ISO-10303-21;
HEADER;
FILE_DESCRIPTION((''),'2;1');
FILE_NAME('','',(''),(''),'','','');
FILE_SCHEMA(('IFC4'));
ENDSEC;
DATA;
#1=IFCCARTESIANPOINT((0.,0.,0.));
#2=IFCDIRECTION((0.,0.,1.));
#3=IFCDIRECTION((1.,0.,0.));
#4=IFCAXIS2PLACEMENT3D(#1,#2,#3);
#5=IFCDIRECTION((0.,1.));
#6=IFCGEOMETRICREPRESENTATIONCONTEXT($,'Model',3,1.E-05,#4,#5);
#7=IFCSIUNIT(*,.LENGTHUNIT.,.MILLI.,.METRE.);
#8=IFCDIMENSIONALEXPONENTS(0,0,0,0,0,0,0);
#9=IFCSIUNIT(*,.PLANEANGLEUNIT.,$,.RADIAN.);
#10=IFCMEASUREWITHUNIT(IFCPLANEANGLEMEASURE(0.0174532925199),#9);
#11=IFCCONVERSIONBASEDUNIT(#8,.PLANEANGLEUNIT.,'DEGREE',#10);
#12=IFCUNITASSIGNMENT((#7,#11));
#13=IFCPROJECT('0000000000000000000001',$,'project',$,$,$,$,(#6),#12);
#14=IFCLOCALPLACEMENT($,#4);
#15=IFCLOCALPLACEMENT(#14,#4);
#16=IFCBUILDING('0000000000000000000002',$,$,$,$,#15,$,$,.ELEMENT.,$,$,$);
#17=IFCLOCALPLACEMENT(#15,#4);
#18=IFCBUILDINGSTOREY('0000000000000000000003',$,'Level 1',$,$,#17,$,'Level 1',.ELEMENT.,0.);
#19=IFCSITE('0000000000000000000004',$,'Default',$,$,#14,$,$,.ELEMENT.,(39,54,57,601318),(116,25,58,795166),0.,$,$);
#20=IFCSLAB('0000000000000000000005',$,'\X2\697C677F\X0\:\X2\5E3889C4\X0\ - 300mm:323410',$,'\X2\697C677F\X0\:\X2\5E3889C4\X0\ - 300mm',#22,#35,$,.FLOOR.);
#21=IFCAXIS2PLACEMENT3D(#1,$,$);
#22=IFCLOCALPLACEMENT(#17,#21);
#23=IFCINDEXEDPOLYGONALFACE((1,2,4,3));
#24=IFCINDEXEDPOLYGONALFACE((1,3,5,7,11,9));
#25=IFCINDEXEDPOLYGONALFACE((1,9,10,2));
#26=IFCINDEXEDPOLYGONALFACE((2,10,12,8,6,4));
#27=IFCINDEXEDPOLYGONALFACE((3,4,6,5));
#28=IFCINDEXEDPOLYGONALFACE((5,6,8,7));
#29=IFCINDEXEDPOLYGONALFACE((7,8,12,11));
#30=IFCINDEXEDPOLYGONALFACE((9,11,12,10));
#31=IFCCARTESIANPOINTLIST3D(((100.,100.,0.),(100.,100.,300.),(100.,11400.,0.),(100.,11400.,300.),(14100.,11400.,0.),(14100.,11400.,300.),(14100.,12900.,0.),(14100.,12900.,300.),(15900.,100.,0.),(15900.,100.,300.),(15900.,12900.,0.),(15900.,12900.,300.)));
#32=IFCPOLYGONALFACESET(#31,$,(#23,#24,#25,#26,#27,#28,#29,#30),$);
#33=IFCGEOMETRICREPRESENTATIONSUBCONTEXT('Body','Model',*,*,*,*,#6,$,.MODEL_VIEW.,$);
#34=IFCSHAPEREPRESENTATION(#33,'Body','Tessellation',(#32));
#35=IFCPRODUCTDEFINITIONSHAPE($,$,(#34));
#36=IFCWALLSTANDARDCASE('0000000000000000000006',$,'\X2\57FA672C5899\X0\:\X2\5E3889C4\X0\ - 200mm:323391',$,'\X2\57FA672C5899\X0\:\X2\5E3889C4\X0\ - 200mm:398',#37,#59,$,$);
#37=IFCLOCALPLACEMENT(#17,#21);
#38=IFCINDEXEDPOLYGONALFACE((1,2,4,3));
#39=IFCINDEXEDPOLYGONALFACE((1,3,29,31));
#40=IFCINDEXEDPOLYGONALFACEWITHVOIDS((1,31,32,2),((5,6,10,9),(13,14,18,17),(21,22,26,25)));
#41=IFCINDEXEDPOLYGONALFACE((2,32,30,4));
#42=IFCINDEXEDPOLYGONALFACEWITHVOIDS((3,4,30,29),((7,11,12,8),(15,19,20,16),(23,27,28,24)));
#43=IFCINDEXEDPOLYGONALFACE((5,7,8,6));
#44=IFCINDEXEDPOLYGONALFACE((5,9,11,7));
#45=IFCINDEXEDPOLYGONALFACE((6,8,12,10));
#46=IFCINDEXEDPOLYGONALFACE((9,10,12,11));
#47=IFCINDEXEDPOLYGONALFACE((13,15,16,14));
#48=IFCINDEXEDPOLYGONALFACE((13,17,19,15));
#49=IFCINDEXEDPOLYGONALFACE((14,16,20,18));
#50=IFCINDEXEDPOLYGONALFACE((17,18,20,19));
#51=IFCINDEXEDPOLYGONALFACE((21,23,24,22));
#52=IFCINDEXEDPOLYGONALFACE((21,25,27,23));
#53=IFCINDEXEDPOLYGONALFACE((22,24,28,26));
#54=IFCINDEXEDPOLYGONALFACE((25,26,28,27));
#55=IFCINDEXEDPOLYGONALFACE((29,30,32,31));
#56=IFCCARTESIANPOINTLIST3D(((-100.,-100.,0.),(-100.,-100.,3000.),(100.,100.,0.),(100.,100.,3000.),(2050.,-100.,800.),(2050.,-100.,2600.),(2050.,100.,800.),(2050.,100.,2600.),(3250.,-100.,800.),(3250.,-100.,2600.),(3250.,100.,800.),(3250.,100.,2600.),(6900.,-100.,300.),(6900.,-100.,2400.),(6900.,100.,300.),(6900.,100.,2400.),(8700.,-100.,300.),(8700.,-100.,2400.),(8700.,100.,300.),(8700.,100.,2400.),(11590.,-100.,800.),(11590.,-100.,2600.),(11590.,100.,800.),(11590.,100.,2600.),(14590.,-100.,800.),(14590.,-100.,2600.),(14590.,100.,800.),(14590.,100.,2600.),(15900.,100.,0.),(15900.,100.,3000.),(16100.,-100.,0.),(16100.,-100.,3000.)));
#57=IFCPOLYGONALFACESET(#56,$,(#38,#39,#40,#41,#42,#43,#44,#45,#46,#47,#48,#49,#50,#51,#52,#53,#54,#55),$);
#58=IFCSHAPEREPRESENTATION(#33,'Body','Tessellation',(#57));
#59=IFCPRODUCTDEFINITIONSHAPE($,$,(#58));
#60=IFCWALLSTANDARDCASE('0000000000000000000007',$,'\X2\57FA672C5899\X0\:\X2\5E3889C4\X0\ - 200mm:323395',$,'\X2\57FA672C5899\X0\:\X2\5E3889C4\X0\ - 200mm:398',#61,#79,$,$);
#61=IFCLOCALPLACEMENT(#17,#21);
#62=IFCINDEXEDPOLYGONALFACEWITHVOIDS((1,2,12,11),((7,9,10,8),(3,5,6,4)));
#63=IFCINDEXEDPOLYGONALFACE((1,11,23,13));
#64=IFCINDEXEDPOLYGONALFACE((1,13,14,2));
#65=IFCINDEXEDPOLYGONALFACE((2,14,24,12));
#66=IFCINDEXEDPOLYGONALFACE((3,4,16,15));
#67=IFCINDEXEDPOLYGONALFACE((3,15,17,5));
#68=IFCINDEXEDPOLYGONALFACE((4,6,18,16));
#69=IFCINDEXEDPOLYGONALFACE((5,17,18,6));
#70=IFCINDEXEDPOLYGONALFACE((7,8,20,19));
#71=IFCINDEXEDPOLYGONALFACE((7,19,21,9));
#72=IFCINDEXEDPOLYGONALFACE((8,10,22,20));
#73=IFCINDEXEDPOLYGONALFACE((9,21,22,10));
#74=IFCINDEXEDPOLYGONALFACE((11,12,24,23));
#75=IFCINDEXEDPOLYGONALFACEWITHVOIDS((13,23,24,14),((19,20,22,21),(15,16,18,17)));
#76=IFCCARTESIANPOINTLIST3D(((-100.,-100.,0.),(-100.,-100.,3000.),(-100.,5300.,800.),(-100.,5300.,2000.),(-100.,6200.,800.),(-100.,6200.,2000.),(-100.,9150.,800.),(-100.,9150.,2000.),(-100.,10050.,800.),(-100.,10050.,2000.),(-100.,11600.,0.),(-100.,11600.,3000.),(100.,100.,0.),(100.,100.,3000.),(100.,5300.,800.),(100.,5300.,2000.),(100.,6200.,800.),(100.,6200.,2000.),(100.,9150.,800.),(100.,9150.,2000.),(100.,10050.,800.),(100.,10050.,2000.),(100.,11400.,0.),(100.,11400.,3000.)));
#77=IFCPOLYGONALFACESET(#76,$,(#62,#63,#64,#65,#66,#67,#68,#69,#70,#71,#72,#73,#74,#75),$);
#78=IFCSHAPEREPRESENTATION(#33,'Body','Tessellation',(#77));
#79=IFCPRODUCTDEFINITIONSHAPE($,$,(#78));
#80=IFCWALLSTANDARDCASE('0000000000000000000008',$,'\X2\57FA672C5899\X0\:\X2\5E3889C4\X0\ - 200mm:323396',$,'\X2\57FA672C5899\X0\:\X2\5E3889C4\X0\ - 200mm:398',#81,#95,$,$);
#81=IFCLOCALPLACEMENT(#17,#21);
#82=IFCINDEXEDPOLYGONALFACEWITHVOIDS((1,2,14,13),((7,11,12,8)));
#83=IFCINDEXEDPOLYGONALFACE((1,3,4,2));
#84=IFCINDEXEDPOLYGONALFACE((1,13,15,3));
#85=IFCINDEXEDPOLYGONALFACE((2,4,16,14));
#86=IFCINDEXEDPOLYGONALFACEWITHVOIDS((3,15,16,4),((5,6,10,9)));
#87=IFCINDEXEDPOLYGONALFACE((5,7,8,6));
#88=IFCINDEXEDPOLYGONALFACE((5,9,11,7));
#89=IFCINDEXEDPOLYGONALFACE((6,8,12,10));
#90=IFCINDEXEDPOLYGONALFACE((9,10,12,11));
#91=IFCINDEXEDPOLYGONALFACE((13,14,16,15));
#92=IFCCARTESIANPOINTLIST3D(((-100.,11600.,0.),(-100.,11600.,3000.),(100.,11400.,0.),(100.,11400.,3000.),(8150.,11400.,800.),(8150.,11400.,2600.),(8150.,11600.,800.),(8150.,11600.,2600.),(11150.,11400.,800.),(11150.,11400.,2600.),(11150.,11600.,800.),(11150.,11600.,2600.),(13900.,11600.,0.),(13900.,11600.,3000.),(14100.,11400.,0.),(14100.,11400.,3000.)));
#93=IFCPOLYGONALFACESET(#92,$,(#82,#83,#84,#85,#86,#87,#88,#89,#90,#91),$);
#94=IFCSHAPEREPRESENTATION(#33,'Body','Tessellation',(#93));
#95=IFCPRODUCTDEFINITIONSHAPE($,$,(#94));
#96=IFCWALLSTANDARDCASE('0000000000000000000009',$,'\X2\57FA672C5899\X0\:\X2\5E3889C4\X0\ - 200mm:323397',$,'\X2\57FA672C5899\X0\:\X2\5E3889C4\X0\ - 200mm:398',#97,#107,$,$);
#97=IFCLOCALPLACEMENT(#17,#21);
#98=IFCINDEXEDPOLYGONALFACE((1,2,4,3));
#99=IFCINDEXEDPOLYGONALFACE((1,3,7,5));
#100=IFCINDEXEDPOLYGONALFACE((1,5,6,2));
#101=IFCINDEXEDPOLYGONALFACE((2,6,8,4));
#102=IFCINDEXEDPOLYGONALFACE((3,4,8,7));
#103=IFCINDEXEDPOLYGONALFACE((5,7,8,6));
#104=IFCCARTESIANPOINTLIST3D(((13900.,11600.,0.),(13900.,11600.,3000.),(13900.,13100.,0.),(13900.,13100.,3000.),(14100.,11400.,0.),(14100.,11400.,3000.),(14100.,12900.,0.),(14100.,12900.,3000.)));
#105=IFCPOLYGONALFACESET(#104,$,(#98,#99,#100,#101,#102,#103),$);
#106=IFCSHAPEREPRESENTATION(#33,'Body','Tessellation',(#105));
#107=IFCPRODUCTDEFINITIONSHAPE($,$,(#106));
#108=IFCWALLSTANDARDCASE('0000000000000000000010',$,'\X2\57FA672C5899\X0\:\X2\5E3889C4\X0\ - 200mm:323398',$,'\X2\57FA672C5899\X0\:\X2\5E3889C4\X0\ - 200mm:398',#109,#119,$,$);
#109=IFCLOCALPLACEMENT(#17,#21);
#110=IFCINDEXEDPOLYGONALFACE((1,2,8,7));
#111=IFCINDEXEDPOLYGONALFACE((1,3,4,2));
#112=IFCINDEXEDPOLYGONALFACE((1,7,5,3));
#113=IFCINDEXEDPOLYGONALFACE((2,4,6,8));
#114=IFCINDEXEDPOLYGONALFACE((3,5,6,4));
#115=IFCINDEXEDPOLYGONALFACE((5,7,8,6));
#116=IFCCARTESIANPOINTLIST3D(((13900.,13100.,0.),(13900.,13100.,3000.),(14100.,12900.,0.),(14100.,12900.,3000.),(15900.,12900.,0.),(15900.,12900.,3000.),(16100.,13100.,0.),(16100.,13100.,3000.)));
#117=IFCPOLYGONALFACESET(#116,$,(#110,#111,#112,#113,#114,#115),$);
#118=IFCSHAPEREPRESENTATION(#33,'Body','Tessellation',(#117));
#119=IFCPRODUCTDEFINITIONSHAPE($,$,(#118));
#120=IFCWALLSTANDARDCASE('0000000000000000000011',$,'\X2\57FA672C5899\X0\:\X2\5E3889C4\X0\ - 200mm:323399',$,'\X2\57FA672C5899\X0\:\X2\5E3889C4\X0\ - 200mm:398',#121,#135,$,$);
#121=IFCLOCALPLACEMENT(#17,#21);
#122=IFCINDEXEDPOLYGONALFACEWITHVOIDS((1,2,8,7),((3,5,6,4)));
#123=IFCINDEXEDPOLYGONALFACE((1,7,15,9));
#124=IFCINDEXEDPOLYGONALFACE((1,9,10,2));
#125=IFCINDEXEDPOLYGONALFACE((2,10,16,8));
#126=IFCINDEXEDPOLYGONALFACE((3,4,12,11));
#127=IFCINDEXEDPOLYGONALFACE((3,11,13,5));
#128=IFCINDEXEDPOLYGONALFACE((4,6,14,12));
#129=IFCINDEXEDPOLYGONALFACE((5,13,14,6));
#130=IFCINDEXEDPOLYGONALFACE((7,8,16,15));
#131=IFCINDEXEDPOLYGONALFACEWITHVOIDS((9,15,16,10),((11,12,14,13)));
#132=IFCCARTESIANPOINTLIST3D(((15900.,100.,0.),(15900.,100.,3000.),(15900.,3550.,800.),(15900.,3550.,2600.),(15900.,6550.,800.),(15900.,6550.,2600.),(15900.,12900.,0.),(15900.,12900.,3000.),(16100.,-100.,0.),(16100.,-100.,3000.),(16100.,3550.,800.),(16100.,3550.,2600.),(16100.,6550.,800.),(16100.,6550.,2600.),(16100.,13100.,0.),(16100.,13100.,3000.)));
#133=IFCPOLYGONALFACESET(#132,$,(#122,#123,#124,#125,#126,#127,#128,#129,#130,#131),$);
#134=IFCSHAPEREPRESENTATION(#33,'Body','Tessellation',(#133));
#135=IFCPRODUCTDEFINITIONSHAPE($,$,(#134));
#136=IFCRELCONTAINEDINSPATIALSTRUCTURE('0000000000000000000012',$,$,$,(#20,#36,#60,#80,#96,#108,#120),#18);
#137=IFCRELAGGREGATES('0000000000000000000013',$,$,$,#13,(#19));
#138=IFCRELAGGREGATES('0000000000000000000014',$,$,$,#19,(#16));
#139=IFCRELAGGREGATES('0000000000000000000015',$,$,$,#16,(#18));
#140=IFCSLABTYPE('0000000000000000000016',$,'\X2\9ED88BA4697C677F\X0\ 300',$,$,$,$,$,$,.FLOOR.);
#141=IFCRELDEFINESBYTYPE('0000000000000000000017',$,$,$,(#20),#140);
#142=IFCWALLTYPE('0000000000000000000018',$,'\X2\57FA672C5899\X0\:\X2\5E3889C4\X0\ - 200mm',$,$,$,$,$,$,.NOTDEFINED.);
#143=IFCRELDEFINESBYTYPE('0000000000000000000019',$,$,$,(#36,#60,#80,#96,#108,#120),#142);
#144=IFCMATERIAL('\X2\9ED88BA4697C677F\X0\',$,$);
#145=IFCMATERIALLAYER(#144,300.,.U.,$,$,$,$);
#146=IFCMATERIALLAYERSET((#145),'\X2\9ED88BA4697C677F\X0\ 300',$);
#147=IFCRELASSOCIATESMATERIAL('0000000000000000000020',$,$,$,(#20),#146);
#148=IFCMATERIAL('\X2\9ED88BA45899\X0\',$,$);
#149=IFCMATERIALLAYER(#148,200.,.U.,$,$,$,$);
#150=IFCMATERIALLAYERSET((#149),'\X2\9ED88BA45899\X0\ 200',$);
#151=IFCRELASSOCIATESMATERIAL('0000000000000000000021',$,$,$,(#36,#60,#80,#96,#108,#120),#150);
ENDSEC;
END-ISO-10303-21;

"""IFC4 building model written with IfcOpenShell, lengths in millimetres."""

from ifc_helpers import new_model, entity, si_unit, converted_unit, direction, frame, origin_with_axes, place, context, subcontext, project, spatial, polyline, outline, extrude, material, layer, layer_set, layer_usage, type_object, element, save


model = new_model("IFC4")

# Units and contexts
model_context = context("Model", 3, precision=1e-05, world=origin_with_axes(), true_north=direction((0.0, 1.0)))
body_context = subcontext(model_context, "Body", "Model", "MODEL_VIEW")
ifc_project = project(units=[si_unit("LENGTHUNIT", "METRE", prefix="MILLI"), converted_unit("PLANEANGLEUNIT", "DEGREE", entity("IfcPlaneAngleMeasure", 0.0174532925199), si_unit("PLANEANGLEUNIT", "RADIAN"), dimensions=[0, 0, 0, 0, 0, 0, 0])], contexts=[model_context])

# Site, building, storey
site_placement = place(None, origin_with_axes())
site = spatial("IfcSite", under=ifc_project, at=site_placement, Name="Default", CompositionType="ELEMENT", RefLatitude=(39, 54, 57, 601318), RefLongitude=(116, 25, 58, 795166), RefElevation=0.0)
building_placement = place(site_placement, origin_with_axes())
building = spatial("IfcBuilding", under=site, at=building_placement, CompositionType="ELEMENT")
storey_placement = place(building_placement, origin_with_axes())
storey = spatial("IfcBuildingStorey", under=building, at=storey_placement, Name="Level 1", LongName="Level 1", CompositionType="ELEMENT", Elevation=0.0)

# Slab
ifc_material_1 = material(Name="默认楼板")
ifc_layer_1 = layer(ifc_material_1, 300.0, ventilated="UNKNOWN")
ifc_layer_set_1 = layer_set([ifc_layer_1], Name="默认楼板 300")
ifc_layer_usage_1 = layer_usage(ifc_layer_set_1, "AXIS3", "NEGATIVE", 300.0)
slab_type = type_object("IfcSlabType", Name="默认楼板 300", PredefinedType="FLOOR")
slab_placement = place(storey_placement, frame((100.0, 100.0, 0.0), z_axis=(0.0, 0.0, 1.0), x_axis=(1.0, 0.0, 0.0)))
element("IfcSlab", 1, at=slab_placement, inside=storey, type_object=slab_type, material=ifc_layer_usage_1, Name="楼板:常规 - 300mm:323410", ObjectType="楼板:常规 - 300mm", PredefinedType="FLOOR", context=body_context, shape_type="SweptSolid", body=[
    extrude(outline(polyline([(0.0, 0.0), (15800.0, 0.0), (15800.0, 12800.0), (14000.0, 12800.0), (14000.0, 11300.0), (0.0, 11300.0), (0.0, 0.0)])), origin_with_axes(), (0.0, 0.0, 1.0), 300.0),
])

# Walls, openings
ifc_material_2 = material(Name="默认墙")
ifc_layer_2 = layer(ifc_material_2, 200.0, ventilated="UNKNOWN")
ifc_layer_set_2 = layer_set([ifc_layer_2], Name="默认墙 200")
ifc_layer_usage_2 = layer_usage(ifc_layer_set_2, "AXIS2", "POSITIVE", -100.0)
wall_type = type_object("IfcWallType", Name="基本墙:常规 - 200mm", PredefinedType="NOTDEFINED")
wall_1_placement = place(storey_placement, frame((16000.0, 0.0, 0.0), z_axis=(0.0, 0.0, 1.0), x_axis=(-1.0, 0.0, 0.0)))
wall_1 = element("IfcWallStandardCase", 2, at=wall_1_placement, inside=storey, type_object=wall_type, material=ifc_layer_usage_2, Name="基本墙:常规 - 200mm:323391", ObjectType="基本墙:常规 - 200mm:398", context=body_context, shape_type="SweptSolid", body=[
    extrude(outline(polyline([(100.0, -100.0), (15900.0, -100.0), (16100.0, 100.0), (-100.0, 100.0), (100.0, -100.0)])), origin_with_axes(), (0.0, 0.0, 1.0), 3000.0),
])
opening_1_placement = place(wall_1_placement, frame((13350.0, 0.0, 800.0), z_axis=(0.0, 0.0, 1.0), x_axis=(1.0, 0.0, 0.0)))
element("IfcOpeningElement", 3, at=opening_1_placement, cuts=wall_1, context=body_context, shape_type="SweptSolid", body=[
    extrude(outline(polyline([(-600.0, 0.0), (-600.0, -1800.0), (600.0, -1800.0), (600.0, 0.0), (-600.0, 0.0)])), frame((0.0, -100.0, 0.0), z_axis=(0.0, 1.0, 0.0), x_axis=(1.0, 0.0, 0.0)), (0.0, 0.0, 1.0), 200.0),
])
opening_2_placement = place(wall_1_placement, frame((2910.0, 0.0, 800.0), z_axis=(0.0, 0.0, 1.0), x_axis=(1.0, 0.0, 0.0)))
element("IfcOpeningElement", 4, at=opening_2_placement, cuts=wall_1, context=body_context, shape_type="SweptSolid", body=[
    extrude(outline(polyline([(-1500.0, 0.0), (-1500.0, -1800.0), (1500.0, -1800.0), (1500.0, 0.0), (-1500.0, 0.0)])), frame((0.0, -100.0, 0.0), z_axis=(0.0, 1.0, 0.0), x_axis=(1.0, 0.0, 0.0)), (0.0, 0.0, 1.0), 200.0),
])
opening_3_placement = place(wall_1_placement, frame((8200.0, 0.0, 300.0), z_axis=(0.0, 0.0, 1.0), x_axis=(1.0, 0.0, 0.0)))
element("IfcOpeningElement", 5, at=opening_3_placement, cuts=wall_1, context=body_context, shape_type="SweptSolid", body=[
    extrude(outline(polyline([(-900.0, 0.0), (-900.0, -2100.0), (900.0, -2100.0), (900.0, 0.0), (-900.0, 0.0)])), frame((0.0, -100.0, 0.0), z_axis=(0.0, 1.0, 0.0), x_axis=(1.0, 0.0, 0.0)), (0.0, 0.0, 1.0), 200.0),
])
ifc_layer_usage_3 = layer_usage(ifc_layer_set_2, "AXIS2", "POSITIVE", -100.0)
wall_2_placement = place(storey_placement, frame((0.0, 0.0, 0.0), z_axis=(0.0, 0.0, 1.0), x_axis=(0.0, 1.0, 0.0)))
wall_2 = element("IfcWallStandardCase", 6, at=wall_2_placement, inside=storey, type_object=wall_type, material=ifc_layer_usage_3, Name="基本墙:常规 - 200mm:323395", ObjectType="基本墙:常规 - 200mm:398", context=body_context, shape_type="SweptSolid", body=[
    extrude(outline(polyline([(100.0, -100.0), (11400.0, -100.0), (11600.0, 100.0), (-100.0, 100.0), (100.0, -100.0)])), origin_with_axes(), (0.0, 0.0, 1.0), 3000.0),
])
opening_4_placement = place(wall_2_placement, frame((5750.0, 0.0, 800.0), z_axis=(0.0, 0.0, 1.0), x_axis=(1.0, 0.0, 0.0)))
element("IfcOpeningElement", 7, at=opening_4_placement, cuts=wall_2, context=body_context, shape_type="SweptSolid", body=[
    extrude(outline(polyline([(450.0, -1200.0), (450.0, 0.0), (-450.0, 0.0), (-450.0, -1200.0), (450.0, -1200.0)])), frame((0.0, 100.0, 0.0), z_axis=(0.0, -1.0, 0.0), x_axis=(-1.0, 0.0, 0.0)), (0.0, 0.0, 1.0), 200.0),
])
opening_5_placement = place(wall_2_placement, frame((9600.0, 0.0, 800.0), z_axis=(0.0, 0.0, 1.0), x_axis=(1.0, 0.0, 0.0)))
element("IfcOpeningElement", 8, at=opening_5_placement, cuts=wall_2, context=body_context, shape_type="SweptSolid", body=[
    extrude(outline(polyline([(450.0, -1200.0), (450.0, 0.0), (-450.0, 0.0), (-450.0, -1200.0), (450.0, -1200.0)])), frame((0.0, 100.0, 0.0), z_axis=(0.0, -1.0, 0.0), x_axis=(-1.0, 0.0, 0.0)), (0.0, 0.0, 1.0), 200.0),
])

# Wall, opening
ifc_layer_usage_4 = layer_usage(ifc_layer_set_2, "AXIS2", "POSITIVE", -100.0)
wall_3_placement = place(storey_placement, frame((0.0, 11500.0, 0.0), z_axis=(0.0, 0.0, 1.0), x_axis=(1.0, 0.0, 0.0)))
wall_3 = element("IfcWallStandardCase", 9, at=wall_3_placement, inside=storey, type_object=wall_type, material=ifc_layer_usage_4, Name="基本墙:常规 - 200mm:323396", ObjectType="基本墙:常规 - 200mm:398", context=body_context, shape_type="SweptSolid", body=[
    extrude(outline(polyline([(100.0, -100.0), (14100.0, -100.0), (13900.0, 100.0), (-100.0, 100.0), (100.0, -100.0)])), origin_with_axes(), (0.0, 0.0, 1.0), 3000.0),
])
opening_6_placement = place(wall_3_placement, frame((9650.0, 0.0, 800.0), z_axis=(0.0, 0.0, 1.0), x_axis=(1.0, 0.0, 0.0)))
element("IfcOpeningElement", 10, at=opening_6_placement, cuts=wall_3, context=body_context, shape_type="SweptSolid", body=[
    extrude(outline(polyline([(-1500.0, 0.0), (-1500.0, -1800.0), (1500.0, -1800.0), (1500.0, 0.0), (-1500.0, 0.0)])), frame((0.0, -100.0, 0.0), z_axis=(0.0, 1.0, 0.0), x_axis=(1.0, 0.0, 0.0)), (0.0, 0.0, 1.0), 200.0),
])

# Walls
ifc_layer_usage_5 = layer_usage(ifc_layer_set_2, "AXIS2", "POSITIVE", -100.0)
wall_4_placement = place(storey_placement, frame((14000.0, 11500.0, 0.0), z_axis=(0.0, 0.0, 1.0), x_axis=(0.0, 1.0, 0.0)))
element("IfcWallStandardCase", 11, at=wall_4_placement, inside=storey, type_object=wall_type, material=ifc_layer_usage_5, Name="基本墙:常规 - 200mm:323397", ObjectType="基本墙:常规 - 200mm:398", context=body_context, shape_type="SweptSolid", body=[
    extrude(outline(polyline([(-100.0, -100.0), (1400.0, -100.0), (1600.0, 100.0), (100.0, 100.0), (-100.0, -100.0)])), origin_with_axes(), (0.0, 0.0, 1.0), 3000.0),
])
ifc_layer_usage_6 = layer_usage(ifc_layer_set_2, "AXIS2", "POSITIVE", -100.0)
wall_5_placement = place(storey_placement, frame((14000.0, 13000.0, 0.0), z_axis=(0.0, 0.0, 1.0), x_axis=(1.0, 0.0, 0.0)))
element("IfcWallStandardCase", 12, at=wall_5_placement, inside=storey, type_object=wall_type, material=ifc_layer_usage_6, Name="基本墙:常规 - 200mm:323398", ObjectType="基本墙:常规 - 200mm:398", context=body_context, shape_type="SweptSolid", body=[
    extrude(outline(polyline([(100.0, -100.0), (1900.0, -100.0), (2100.0, 100.0), (-100.0, 100.0), (100.0, -100.0)])), origin_with_axes(), (0.0, 0.0, 1.0), 3000.0),
])

# Wall, opening
ifc_layer_usage_7 = layer_usage(ifc_layer_set_2, "AXIS2", "POSITIVE", -100.0)
wall_6_placement = place(storey_placement, frame((16000.0, 13000.0, 0.0), z_axis=(0.0, 0.0, 1.0), x_axis=(0.0, -1.0, 0.0)))
wall_6 = element("IfcWallStandardCase", 13, at=wall_6_placement, inside=storey, type_object=wall_type, material=ifc_layer_usage_7, Name="基本墙:常规 - 200mm:323399", ObjectType="基本墙:常规 - 200mm:398", context=body_context, shape_type="SweptSolid", body=[
    extrude(outline(polyline([(100.0, -100.0), (12900.0, -100.0), (13100.0, 100.0), (-100.0, 100.0), (100.0, -100.0)])), origin_with_axes(), (0.0, 0.0, 1.0), 3000.0),
])
opening_7_placement = place(wall_6_placement, frame((7950.0, 0.0, 800.0), z_axis=(0.0, 0.0, 1.0), x_axis=(1.0, 0.0, 0.0)))
element("IfcOpeningElement", 14, at=opening_7_placement, cuts=wall_6, context=body_context, shape_type="SweptSolid", body=[
    extrude(outline(polyline([(-1500.0, 0.0), (-1500.0, -1800.0), (1500.0, -1800.0), (1500.0, 0.0), (-1500.0, 0.0)])), frame((0.0, -100.0, 0.0), z_axis=(0.0, 1.0, 0.0), x_axis=(1.0, 0.0, 0.0)), (0.0, 0.0, 1.0), 200.0),
])

save(model, "model.ifc")
